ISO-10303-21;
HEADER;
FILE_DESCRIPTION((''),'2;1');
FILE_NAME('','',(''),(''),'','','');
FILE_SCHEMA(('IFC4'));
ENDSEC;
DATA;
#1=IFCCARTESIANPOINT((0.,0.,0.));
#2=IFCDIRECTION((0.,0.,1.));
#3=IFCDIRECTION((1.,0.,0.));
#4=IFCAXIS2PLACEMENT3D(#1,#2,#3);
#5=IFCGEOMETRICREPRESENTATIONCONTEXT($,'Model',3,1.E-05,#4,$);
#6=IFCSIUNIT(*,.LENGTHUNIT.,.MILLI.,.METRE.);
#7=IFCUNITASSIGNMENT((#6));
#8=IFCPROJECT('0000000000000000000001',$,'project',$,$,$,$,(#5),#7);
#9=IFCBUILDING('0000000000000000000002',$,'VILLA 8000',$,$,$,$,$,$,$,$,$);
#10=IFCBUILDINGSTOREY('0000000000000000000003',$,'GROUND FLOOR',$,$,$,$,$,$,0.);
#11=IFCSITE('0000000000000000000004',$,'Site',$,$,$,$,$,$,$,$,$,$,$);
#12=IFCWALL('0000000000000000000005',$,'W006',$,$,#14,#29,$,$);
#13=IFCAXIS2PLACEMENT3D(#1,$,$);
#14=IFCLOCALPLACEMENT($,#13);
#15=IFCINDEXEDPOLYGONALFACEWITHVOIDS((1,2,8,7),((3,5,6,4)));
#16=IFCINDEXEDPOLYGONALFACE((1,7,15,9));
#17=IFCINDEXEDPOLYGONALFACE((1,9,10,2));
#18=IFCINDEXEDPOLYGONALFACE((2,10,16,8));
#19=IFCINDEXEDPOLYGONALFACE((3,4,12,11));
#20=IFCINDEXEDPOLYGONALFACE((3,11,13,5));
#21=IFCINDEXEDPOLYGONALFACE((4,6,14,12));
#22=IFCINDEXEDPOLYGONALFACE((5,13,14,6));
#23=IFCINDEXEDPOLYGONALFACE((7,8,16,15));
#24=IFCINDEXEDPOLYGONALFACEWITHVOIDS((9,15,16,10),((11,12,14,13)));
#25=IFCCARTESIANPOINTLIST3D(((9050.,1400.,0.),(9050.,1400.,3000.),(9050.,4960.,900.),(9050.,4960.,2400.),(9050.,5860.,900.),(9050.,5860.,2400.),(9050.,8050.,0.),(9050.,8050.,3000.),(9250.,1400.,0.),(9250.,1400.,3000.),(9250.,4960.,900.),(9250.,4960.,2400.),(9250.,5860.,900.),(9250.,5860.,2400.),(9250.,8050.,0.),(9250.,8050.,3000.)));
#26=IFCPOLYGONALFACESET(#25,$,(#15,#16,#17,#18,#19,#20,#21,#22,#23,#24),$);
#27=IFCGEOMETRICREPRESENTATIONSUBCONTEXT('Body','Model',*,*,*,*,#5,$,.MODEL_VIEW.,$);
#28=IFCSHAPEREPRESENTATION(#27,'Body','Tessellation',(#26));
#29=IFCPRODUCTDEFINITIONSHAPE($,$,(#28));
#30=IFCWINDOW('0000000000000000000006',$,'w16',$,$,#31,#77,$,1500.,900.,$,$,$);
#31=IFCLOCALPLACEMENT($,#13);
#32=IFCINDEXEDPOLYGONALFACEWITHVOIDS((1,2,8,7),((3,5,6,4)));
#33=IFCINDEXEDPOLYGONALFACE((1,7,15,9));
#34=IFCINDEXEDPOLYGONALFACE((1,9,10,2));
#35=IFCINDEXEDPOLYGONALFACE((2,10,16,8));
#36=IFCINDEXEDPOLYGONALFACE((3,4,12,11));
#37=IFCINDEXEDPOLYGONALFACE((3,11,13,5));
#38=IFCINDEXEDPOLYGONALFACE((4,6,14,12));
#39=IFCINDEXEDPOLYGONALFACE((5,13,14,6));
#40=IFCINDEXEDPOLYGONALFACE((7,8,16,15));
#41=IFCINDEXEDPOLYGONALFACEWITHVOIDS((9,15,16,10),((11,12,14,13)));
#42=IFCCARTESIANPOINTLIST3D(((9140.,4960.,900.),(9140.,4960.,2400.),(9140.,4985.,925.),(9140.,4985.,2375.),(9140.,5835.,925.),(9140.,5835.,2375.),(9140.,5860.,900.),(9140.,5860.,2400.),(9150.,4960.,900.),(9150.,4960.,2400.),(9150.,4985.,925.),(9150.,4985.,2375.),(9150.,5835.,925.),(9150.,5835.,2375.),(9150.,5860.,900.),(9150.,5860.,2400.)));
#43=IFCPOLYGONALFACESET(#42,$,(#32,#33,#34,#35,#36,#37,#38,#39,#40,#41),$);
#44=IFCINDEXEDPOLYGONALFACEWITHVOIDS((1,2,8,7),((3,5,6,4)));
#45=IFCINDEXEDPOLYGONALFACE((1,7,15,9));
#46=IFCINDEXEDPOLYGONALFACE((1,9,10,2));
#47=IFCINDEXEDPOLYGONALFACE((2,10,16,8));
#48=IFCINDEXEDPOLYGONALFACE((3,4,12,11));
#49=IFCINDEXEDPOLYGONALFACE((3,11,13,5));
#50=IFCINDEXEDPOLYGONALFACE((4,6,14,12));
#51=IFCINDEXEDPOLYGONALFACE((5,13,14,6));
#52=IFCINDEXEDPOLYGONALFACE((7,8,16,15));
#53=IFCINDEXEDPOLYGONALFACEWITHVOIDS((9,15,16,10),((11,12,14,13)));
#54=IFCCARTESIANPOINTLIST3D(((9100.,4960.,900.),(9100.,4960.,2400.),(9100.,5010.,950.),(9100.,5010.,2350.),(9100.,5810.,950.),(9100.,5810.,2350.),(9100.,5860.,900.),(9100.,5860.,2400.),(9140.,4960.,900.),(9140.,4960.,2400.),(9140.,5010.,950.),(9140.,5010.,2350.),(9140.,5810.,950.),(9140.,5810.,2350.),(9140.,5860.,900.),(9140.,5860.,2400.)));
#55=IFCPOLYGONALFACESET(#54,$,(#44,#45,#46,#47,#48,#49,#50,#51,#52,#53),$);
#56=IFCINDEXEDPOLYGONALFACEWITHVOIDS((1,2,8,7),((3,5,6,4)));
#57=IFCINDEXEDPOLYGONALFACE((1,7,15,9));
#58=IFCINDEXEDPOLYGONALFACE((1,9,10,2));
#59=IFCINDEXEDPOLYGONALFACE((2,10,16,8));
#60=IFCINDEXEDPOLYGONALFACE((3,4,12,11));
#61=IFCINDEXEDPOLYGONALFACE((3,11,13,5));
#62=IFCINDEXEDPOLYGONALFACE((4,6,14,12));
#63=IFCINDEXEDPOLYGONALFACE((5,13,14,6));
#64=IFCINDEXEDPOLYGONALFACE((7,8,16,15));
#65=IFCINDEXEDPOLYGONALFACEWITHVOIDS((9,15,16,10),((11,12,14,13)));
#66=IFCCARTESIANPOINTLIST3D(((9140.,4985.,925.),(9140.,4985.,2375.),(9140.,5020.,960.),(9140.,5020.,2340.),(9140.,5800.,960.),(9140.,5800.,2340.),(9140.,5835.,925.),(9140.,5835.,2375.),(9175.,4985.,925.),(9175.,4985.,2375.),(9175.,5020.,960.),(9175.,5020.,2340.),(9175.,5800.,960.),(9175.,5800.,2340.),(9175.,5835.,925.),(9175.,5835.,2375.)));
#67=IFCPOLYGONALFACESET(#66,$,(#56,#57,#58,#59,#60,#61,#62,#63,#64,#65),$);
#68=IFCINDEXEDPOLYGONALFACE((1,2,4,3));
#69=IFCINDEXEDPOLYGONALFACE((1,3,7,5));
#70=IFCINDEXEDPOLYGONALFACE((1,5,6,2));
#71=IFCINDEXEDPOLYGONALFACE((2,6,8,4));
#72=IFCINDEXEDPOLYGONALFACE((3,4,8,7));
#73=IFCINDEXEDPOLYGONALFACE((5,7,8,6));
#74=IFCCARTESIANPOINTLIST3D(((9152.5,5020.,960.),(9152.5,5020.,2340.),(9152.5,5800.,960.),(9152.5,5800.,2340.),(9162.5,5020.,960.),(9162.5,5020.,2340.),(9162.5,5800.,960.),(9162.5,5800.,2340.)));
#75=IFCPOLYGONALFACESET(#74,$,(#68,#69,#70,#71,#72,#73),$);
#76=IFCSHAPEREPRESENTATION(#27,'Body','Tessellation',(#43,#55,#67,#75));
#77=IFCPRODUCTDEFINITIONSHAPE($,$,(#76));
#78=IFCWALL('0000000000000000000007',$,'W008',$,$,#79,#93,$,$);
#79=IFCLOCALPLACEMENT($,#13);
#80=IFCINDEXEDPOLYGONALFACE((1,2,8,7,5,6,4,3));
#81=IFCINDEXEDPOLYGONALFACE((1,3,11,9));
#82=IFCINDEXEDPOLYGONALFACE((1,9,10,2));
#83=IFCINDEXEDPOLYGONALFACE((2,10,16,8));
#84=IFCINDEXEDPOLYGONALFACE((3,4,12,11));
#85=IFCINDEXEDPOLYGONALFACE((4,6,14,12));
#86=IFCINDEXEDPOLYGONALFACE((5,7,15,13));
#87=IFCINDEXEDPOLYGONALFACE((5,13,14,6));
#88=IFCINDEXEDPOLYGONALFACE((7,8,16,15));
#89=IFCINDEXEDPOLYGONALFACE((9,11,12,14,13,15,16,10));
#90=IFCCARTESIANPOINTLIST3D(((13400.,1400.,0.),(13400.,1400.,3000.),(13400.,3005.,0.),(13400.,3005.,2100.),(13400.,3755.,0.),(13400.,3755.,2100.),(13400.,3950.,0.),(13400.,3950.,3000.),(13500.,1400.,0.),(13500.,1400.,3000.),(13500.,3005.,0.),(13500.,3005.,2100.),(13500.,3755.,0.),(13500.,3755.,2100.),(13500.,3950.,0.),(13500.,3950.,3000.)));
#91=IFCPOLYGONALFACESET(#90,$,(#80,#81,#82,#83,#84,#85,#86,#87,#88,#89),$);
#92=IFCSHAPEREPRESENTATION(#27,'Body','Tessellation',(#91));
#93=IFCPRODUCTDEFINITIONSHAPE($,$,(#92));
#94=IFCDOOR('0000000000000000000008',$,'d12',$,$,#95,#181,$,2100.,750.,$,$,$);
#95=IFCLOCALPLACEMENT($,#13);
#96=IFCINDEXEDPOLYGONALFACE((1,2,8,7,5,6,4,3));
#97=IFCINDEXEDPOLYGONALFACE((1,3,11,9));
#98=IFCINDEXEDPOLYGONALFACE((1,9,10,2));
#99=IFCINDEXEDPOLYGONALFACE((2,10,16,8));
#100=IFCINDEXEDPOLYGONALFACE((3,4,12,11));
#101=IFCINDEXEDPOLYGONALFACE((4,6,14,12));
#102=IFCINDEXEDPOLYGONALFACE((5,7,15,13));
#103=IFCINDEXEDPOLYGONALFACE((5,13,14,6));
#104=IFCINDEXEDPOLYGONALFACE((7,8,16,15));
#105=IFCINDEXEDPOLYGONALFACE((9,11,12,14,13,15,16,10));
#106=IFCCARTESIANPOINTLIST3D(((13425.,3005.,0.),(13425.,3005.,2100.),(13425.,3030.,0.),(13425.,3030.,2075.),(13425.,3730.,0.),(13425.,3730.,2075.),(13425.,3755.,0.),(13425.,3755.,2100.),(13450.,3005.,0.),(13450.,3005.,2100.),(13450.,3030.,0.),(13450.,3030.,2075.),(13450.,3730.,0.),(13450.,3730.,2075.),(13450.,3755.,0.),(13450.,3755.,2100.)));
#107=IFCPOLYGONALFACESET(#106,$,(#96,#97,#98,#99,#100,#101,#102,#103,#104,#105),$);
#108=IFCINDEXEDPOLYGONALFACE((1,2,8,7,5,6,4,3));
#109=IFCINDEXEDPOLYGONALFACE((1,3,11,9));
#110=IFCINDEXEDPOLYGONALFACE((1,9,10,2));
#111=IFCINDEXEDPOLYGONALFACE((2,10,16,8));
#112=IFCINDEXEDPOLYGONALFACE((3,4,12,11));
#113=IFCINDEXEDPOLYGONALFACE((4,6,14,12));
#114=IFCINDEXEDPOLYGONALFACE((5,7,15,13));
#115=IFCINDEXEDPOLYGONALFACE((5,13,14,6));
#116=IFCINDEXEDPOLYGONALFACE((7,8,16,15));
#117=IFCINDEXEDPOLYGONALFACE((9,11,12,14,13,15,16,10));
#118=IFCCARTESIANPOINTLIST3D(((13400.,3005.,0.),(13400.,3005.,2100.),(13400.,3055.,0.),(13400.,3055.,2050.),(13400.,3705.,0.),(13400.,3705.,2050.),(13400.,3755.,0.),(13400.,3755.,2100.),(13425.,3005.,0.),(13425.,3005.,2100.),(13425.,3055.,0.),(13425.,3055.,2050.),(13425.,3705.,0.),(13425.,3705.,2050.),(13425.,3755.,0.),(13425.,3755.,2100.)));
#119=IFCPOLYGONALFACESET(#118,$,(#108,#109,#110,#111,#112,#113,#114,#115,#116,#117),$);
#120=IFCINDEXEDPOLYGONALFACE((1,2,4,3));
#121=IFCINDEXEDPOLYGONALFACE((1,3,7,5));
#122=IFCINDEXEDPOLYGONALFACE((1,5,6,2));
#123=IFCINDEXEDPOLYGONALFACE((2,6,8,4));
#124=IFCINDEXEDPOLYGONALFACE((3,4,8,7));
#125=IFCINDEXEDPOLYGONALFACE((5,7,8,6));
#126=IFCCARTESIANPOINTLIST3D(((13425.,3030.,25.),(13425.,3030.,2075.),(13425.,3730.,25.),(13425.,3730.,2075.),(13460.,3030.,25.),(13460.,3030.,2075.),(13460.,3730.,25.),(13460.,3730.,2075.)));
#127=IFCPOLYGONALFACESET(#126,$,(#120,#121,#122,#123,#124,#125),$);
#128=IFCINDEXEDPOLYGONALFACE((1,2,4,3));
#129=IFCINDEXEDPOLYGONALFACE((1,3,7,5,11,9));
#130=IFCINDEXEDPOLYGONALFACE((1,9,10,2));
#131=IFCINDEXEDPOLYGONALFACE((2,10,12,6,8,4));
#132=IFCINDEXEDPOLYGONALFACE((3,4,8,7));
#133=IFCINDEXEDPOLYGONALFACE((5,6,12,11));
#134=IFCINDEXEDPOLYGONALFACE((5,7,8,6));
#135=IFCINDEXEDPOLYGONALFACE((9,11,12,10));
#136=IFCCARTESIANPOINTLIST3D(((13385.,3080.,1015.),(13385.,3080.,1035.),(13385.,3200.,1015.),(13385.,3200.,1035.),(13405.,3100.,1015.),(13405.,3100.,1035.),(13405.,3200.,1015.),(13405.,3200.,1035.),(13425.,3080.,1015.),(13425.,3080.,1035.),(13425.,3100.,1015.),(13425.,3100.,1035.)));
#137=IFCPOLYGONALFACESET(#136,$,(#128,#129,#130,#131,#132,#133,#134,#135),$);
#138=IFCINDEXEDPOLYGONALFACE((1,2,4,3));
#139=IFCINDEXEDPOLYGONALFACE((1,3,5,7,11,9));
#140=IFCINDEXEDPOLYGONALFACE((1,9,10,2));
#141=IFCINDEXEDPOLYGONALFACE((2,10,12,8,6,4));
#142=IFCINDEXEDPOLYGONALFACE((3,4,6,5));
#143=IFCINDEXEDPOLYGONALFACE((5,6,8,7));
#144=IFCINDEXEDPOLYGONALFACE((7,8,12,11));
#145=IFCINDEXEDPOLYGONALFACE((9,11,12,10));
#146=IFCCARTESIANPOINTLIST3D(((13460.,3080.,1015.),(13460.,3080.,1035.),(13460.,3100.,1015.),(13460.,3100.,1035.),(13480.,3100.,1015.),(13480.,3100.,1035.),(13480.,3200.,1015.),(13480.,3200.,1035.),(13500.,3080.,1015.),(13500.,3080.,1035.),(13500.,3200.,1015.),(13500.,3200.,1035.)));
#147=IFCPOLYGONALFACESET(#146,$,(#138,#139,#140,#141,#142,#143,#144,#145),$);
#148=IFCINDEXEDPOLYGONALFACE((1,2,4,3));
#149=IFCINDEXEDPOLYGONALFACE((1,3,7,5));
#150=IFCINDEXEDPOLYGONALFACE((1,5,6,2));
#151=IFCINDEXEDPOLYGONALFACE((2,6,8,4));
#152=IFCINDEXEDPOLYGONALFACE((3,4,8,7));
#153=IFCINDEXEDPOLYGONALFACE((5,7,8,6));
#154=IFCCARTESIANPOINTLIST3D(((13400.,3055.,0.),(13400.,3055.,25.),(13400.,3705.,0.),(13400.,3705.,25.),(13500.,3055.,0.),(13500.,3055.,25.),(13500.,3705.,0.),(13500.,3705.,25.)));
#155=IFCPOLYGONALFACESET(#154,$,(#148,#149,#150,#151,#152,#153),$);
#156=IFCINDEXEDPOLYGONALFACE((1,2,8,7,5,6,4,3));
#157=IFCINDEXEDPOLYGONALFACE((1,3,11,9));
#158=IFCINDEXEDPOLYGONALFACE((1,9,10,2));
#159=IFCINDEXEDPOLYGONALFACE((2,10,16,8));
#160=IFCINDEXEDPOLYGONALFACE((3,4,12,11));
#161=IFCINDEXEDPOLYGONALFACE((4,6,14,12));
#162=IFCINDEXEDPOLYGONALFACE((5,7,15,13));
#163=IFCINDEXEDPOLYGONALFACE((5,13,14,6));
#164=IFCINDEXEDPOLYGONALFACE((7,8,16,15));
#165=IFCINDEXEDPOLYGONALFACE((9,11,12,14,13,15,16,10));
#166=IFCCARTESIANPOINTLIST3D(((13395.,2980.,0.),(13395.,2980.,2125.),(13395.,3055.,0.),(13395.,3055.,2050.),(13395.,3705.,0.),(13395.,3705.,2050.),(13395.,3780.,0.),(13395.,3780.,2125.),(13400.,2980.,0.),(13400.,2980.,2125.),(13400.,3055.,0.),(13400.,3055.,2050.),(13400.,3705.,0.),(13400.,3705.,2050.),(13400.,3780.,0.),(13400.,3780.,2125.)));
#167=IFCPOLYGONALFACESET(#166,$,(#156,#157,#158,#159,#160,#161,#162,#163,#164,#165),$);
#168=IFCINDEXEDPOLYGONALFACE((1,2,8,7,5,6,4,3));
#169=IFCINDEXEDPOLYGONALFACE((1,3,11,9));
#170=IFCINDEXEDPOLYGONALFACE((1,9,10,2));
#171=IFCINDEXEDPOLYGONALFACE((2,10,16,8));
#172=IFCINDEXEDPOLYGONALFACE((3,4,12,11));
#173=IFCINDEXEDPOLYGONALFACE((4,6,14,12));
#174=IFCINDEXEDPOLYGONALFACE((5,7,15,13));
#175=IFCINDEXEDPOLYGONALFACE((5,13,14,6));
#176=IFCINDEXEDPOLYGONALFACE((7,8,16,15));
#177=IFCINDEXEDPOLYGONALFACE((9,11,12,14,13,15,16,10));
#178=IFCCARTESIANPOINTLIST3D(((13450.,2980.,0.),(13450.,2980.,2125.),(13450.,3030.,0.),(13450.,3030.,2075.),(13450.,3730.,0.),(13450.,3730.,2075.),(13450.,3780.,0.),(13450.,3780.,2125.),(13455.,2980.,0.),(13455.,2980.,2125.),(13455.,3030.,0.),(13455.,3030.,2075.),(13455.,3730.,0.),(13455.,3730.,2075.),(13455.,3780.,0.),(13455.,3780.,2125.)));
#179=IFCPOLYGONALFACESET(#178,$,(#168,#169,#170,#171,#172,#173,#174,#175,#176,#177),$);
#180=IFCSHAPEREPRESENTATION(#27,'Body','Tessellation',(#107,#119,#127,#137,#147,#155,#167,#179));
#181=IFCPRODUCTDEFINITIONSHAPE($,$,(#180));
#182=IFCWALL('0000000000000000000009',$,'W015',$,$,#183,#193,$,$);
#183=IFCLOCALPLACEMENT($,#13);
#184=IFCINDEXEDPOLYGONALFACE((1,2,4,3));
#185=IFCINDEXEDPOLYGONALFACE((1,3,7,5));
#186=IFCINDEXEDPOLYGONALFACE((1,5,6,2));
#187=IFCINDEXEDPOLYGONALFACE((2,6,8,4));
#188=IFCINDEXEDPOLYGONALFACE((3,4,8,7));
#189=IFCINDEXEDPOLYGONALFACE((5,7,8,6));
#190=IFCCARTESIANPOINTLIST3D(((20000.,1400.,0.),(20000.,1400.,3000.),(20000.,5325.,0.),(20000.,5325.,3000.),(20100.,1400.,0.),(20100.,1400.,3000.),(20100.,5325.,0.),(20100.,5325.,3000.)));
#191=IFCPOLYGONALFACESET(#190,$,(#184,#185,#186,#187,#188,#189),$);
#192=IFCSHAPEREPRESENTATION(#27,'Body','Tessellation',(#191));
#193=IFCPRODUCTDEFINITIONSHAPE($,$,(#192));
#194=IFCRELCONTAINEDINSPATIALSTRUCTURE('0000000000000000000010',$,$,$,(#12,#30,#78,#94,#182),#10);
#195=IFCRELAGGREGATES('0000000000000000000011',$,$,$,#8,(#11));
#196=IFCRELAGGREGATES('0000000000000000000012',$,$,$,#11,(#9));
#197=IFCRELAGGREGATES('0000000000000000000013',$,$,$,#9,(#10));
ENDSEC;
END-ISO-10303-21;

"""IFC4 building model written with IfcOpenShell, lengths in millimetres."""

from ifc_helpers import new_model, si_unit, frame, origin_with_axes, place, context, subcontext, project, spatial, line, indexed_curve, outline, extrude, element, fill, save


model = new_model("IFC4")

# Units and contexts
model_context = context("Model", 3, precision=1e-05, world=origin_with_axes())
body_context = subcontext(model_context, "Body", "Model", "MODEL_VIEW")
ifc_project = project(units=[si_unit("LENGTHUNIT", "METRE", prefix="MILLI")], contexts=[model_context])

# Site, building, storey
site = spatial("IfcSite", under=ifc_project, Name="Site")
building = spatial("IfcBuilding", under=site, Name="VILLA 8000")
storey = spatial("IfcBuildingStorey", under=building, Name="GROUND FLOOR", Elevation=0.0)

# Wall, opening, window
wall_1_placement = place(None, frame((9150.0, 8050.0, 0.0), z_axis=(0.0, 0.0, 1.0), x_axis=(0.0, -1.0, 0.0)))
wall_1 = element("IfcWall", 1, at=wall_1_placement, inside=storey, Name="W006", context=body_context, shape_type="SweptSolid", body=[
    extrude(outline(indexed_curve([(0.0, 0.0), (0.0, 200.0), (6650.0, 200.0), (6650.0, 0.0), (0.0, 0.0)], self_intersect=False)), frame((0.0, -100.0, 0.0), z_axis=(0.0, 0.0, 1.0), x_axis=(1.0, 0.0, 0.0)), (0.0, 0.0, 1.0), 3000.0),
])
opening_1_placement = place(wall_1_placement, frame((2190.0, 0.0, 900.0), z_axis=(0.0, 0.0, 1.0), x_axis=(1.0, 0.0, 0.0)))
opening_1 = element("IfcOpeningElement", 2, at=opening_1_placement, cuts=wall_1, context=body_context, shape_type="SweptSolid", body=[
    extrude(outline(indexed_curve([(0.0, 0.0), (0.0, 300.0), (900.0, 300.0), (900.0, 0.0), (0.0, 0.0)], self_intersect=False)), frame((0.0, -150.0, 0.0), z_axis=(0.0, 0.0, 1.0), x_axis=(1.0, 0.0, 0.0)), (0.0, 0.0, 1.0), 1500.0),
])
window_1_placement = place(None, frame((9050.0, 5860.0, 900.0), z_axis=(0.0, 0.0, 1.0), x_axis=(0.0, -1.0, 0.0)))
window_1 = element("IfcWindow", 3, at=window_1_placement, inside=storey, Name="w16", OverallHeight=1500.0, OverallWidth=900.0, context=body_context, shape_type="SweptSolid", body=[
    extrude(outline(indexed_curve([(0.0, 0.0), (900.0, 0.0), (900.0, 1500.0), (0.0, 1500.0)], segments=[line(1, 2, 3, 4, 1)]), holes=[indexed_curve([(25.0, 25.0), (875.0, 25.0), (875.0, 1475.0), (25.0, 1475.0)], segments=[line(1, 2, 3, 4, 1)])]), frame((0.0, 90.0, 0.0), z_axis=(0.0, -1.0, 0.0), x_axis=(1.0, 0.0, 0.0)), (0.0, 0.0, -1.0), 10.0),
    extrude(outline(indexed_curve([(0.0, 0.0), (900.0, 0.0), (900.0, 1500.0), (0.0, 1500.0)], segments=[line(1, 2, 3, 4, 1)]), holes=[indexed_curve([(50.0, 50.0), (850.0, 50.0), (850.0, 1450.0), (50.0, 1450.0)], segments=[line(1, 2, 3, 4, 1)])]), frame((0.0, 50.0, 0.0), z_axis=(0.0, -1.0, 0.0), x_axis=(1.0, 0.0, 0.0)), (0.0, 0.0, -1.0), 40.0),
    extrude(outline(indexed_curve([(0.0, 0.0), (850.0, 0.0), (850.0, 1450.0), (0.0, 1450.0)], segments=[line(1, 2, 3, 4, 1)]), holes=[indexed_curve([(35.0, 35.0), (815.0, 35.0), (815.0, 1415.0), (35.0, 1415.0)], segments=[line(1, 2, 3, 4, 1)])]), frame((25.0, 90.0, 25.0), z_axis=(0.0, -1.0, 0.0), x_axis=(1.0, 0.0, 0.0)), (0.0, 0.0, -1.0), 35.0),
    extrude(outline(indexed_curve([(35.0, 35.0), (815.0, 35.0), (815.0, 1415.0), (35.0, 1415.0)], segments=[line(1, 2, 3, 4, 1)])), frame((25.0, 102.5, 25.0), z_axis=(0.0, -1.0, 0.0), x_axis=(1.0, 0.0, 0.0)), (0.0, 0.0, -1.0), 10.0),
])
fill(opening_1, window_1)

# Wall, opening, door
wall_2_placement = place(None, frame((13450.0, 3950.0, 0.0), z_axis=(0.0, 0.0, 1.0), x_axis=(0.0, -1.0, 0.0)))
wall_2 = element("IfcWall", 4, at=wall_2_placement, inside=storey, Name="W008", context=body_context, shape_type="SweptSolid", body=[
    extrude(outline(indexed_curve([(0.0, 0.0), (0.0, 100.0), (2550.0, 100.0), (2550.0, 0.0), (0.0, 0.0)], self_intersect=False)), frame((0.0, -50.0, 0.0), z_axis=(0.0, 0.0, 1.0), x_axis=(1.0, 0.0, 0.0)), (0.0, 0.0, 1.0), 3000.0),
])
opening_2_placement = place(wall_2_placement, frame((195.0, 0.0, 0.0), z_axis=(0.0, 0.0, 1.0), x_axis=(1.0, 0.0, 0.0)))
opening_2 = element("IfcOpeningElement", 5, at=opening_2_placement, cuts=wall_2, context=body_context, shape_type="SweptSolid", body=[
    extrude(outline(indexed_curve([(0.0, 0.0), (0.0, 200.0), (750.0, 200.0), (750.0, 0.0), (0.0, 0.0)], self_intersect=False)), frame((0.0, -100.0, 0.0), z_axis=(0.0, 0.0, 1.0), x_axis=(1.0, 0.0, 0.0)), (0.0, 0.0, 1.0), 2100.0),
])
door_1_placement = place(None, frame((13400.0, 3755.0, 0.0), z_axis=(0.0, 0.0, 1.0), x_axis=(0.0, -1.0, 0.0)))
door_1 = element("IfcDoor", 6, at=door_1_placement, inside=storey, Name="d12", OverallHeight=2100.0, OverallWidth=750.0, context=body_context, shape_type="SweptSolid", body=[
    extrude(outline(indexed_curve([(0.0, 0.0), (0.0, 2100.0), (750.0, 2100.0), (750.0, 0.0), (725.0, 0.0), (725.0, 2075.0), (25.0, 2075.0), (25.0, 0.0)], segments=[line(1, 2, 3, 4, 5, 6, 7, 8, 1)])), frame((0.0, 25.0, 0.0), z_axis=(0.0, -1.0, 0.0), x_axis=(1.0, 0.0, 0.0)), (0.0, 0.0, -1.0), 25.0),
    extrude(outline(indexed_curve([(0.0, 0.0), (0.0, 2100.0), (750.0, 2100.0), (750.0, 0.0), (700.0, 0.0), (700.0, 2050.0), (50.0, 2050.0), (50.0, 0.0)], segments=[line(1, 2, 3, 4, 5, 6, 7, 8, 1)])), frame((0.0, 0.0, 0.0), z_axis=(0.0, -1.0, 0.0), x_axis=(1.0, 0.0, 0.0)), (0.0, 0.0, -1.0), 25.0),
    extrude(outline(indexed_curve([(0.0, 0.0), (700.0, 0.0), (700.0, 35.0), (0.0, 35.0)], segments=[line(1, 2, 3, 4, 1)])), frame((25.0, 25.0, 25.0), z_axis=(0.0, 0.0, 1.0), x_axis=(1.0, 0.0, 0.0)), (0.0, 0.0, 1.0), 2050.0),
    extrude(outline(indexed_curve([(0.0, 0.0), (0.0, -40.0), (-120.0, -40.0), (-120.0, -20.0), (-20.0, -20.0), (-20.0, 0.0)], segments=[line(1, 2, 3, 4, 5, 6, 1)])), frame((675.0, 25.0, 1015.0), z_axis=(0.0, 0.0, 1.0), x_axis=(1.0, 0.0, 0.0)), (0.0, 0.0, 1.0), 20.0),
    extrude(outline(indexed_curve([(0.0, 0.0), (0.0, 40.0), (-120.0, 40.0), (-120.0, 20.0), (-20.0, 20.0), (-20.0, 0.0)], segments=[line(1, 2, 3, 4, 5, 6, 1)])), frame((675.0, 60.0, 1015.0), z_axis=(0.0, 0.0, 1.0), x_axis=(1.0, 0.0, 0.0)), (0.0, 0.0, 1.0), 20.0),
    extrude(outline(indexed_curve([(0.0, 0.0), (650.0, 0.0), (650.0, 100.0), (0.0, 100.0)], segments=[line(1, 2, 3, 4, 1)])), frame((50.0, 0.0, 0.0), z_axis=(0.0, 0.0, 1.0), x_axis=(1.0, 0.0, 0.0)), (0.0, 0.0, 1.0), 25.0),
    extrude(outline(indexed_curve([(0.0, 0.0), (0.0, 2125.0), (800.0, 2125.0), (800.0, 0.0), (725.0, 0.0), (725.0, 2050.0), (75.0, 2050.0), (75.0, 0.0)], segments=[line(1, 2, 3, 4, 5, 6, 7, 8, 1)])), frame((-25.0, -5.0, 0.0), z_axis=(0.0, -1.0, 0.0), x_axis=(1.0, 0.0, 0.0)), (0.0, 0.0, -1.0), 5.0),
    extrude(outline(indexed_curve([(0.0, 0.0), (0.0, 2125.0), (800.0, 2125.0), (800.0, 0.0), (750.0, 0.0), (750.0, 2075.0), (50.0, 2075.0), (50.0, 0.0)], segments=[line(1, 2, 3, 4, 5, 6, 7, 8, 1)])), frame((-25.0, 50.0, 0.0), z_axis=(0.0, -1.0, 0.0), x_axis=(1.0, 0.0, 0.0)), (0.0, 0.0, -1.0), 5.0),
])
fill(opening_2, door_1)

# Wall
wall_3_placement = place(None, frame((20050.0, 5325.0, 0.0), z_axis=(0.0, 0.0, 1.0), x_axis=(0.0, -1.0, 0.0)))
element("IfcWall", 7, at=wall_3_placement, inside=storey, Name="W015", context=body_context, shape_type="SweptSolid", body=[
    extrude(outline(indexed_curve([(0.0, 0.0), (0.0, 100.0), (3925.0, 100.0), (3925.0, 0.0), (0.0, 0.0)], self_intersect=False)), frame((0.0, -50.0, 0.0), z_axis=(0.0, 0.0, 1.0), x_axis=(1.0, 0.0, 0.0)), (0.0, 0.0, 1.0), 3000.0),
])

save(model, "model.ifc")
